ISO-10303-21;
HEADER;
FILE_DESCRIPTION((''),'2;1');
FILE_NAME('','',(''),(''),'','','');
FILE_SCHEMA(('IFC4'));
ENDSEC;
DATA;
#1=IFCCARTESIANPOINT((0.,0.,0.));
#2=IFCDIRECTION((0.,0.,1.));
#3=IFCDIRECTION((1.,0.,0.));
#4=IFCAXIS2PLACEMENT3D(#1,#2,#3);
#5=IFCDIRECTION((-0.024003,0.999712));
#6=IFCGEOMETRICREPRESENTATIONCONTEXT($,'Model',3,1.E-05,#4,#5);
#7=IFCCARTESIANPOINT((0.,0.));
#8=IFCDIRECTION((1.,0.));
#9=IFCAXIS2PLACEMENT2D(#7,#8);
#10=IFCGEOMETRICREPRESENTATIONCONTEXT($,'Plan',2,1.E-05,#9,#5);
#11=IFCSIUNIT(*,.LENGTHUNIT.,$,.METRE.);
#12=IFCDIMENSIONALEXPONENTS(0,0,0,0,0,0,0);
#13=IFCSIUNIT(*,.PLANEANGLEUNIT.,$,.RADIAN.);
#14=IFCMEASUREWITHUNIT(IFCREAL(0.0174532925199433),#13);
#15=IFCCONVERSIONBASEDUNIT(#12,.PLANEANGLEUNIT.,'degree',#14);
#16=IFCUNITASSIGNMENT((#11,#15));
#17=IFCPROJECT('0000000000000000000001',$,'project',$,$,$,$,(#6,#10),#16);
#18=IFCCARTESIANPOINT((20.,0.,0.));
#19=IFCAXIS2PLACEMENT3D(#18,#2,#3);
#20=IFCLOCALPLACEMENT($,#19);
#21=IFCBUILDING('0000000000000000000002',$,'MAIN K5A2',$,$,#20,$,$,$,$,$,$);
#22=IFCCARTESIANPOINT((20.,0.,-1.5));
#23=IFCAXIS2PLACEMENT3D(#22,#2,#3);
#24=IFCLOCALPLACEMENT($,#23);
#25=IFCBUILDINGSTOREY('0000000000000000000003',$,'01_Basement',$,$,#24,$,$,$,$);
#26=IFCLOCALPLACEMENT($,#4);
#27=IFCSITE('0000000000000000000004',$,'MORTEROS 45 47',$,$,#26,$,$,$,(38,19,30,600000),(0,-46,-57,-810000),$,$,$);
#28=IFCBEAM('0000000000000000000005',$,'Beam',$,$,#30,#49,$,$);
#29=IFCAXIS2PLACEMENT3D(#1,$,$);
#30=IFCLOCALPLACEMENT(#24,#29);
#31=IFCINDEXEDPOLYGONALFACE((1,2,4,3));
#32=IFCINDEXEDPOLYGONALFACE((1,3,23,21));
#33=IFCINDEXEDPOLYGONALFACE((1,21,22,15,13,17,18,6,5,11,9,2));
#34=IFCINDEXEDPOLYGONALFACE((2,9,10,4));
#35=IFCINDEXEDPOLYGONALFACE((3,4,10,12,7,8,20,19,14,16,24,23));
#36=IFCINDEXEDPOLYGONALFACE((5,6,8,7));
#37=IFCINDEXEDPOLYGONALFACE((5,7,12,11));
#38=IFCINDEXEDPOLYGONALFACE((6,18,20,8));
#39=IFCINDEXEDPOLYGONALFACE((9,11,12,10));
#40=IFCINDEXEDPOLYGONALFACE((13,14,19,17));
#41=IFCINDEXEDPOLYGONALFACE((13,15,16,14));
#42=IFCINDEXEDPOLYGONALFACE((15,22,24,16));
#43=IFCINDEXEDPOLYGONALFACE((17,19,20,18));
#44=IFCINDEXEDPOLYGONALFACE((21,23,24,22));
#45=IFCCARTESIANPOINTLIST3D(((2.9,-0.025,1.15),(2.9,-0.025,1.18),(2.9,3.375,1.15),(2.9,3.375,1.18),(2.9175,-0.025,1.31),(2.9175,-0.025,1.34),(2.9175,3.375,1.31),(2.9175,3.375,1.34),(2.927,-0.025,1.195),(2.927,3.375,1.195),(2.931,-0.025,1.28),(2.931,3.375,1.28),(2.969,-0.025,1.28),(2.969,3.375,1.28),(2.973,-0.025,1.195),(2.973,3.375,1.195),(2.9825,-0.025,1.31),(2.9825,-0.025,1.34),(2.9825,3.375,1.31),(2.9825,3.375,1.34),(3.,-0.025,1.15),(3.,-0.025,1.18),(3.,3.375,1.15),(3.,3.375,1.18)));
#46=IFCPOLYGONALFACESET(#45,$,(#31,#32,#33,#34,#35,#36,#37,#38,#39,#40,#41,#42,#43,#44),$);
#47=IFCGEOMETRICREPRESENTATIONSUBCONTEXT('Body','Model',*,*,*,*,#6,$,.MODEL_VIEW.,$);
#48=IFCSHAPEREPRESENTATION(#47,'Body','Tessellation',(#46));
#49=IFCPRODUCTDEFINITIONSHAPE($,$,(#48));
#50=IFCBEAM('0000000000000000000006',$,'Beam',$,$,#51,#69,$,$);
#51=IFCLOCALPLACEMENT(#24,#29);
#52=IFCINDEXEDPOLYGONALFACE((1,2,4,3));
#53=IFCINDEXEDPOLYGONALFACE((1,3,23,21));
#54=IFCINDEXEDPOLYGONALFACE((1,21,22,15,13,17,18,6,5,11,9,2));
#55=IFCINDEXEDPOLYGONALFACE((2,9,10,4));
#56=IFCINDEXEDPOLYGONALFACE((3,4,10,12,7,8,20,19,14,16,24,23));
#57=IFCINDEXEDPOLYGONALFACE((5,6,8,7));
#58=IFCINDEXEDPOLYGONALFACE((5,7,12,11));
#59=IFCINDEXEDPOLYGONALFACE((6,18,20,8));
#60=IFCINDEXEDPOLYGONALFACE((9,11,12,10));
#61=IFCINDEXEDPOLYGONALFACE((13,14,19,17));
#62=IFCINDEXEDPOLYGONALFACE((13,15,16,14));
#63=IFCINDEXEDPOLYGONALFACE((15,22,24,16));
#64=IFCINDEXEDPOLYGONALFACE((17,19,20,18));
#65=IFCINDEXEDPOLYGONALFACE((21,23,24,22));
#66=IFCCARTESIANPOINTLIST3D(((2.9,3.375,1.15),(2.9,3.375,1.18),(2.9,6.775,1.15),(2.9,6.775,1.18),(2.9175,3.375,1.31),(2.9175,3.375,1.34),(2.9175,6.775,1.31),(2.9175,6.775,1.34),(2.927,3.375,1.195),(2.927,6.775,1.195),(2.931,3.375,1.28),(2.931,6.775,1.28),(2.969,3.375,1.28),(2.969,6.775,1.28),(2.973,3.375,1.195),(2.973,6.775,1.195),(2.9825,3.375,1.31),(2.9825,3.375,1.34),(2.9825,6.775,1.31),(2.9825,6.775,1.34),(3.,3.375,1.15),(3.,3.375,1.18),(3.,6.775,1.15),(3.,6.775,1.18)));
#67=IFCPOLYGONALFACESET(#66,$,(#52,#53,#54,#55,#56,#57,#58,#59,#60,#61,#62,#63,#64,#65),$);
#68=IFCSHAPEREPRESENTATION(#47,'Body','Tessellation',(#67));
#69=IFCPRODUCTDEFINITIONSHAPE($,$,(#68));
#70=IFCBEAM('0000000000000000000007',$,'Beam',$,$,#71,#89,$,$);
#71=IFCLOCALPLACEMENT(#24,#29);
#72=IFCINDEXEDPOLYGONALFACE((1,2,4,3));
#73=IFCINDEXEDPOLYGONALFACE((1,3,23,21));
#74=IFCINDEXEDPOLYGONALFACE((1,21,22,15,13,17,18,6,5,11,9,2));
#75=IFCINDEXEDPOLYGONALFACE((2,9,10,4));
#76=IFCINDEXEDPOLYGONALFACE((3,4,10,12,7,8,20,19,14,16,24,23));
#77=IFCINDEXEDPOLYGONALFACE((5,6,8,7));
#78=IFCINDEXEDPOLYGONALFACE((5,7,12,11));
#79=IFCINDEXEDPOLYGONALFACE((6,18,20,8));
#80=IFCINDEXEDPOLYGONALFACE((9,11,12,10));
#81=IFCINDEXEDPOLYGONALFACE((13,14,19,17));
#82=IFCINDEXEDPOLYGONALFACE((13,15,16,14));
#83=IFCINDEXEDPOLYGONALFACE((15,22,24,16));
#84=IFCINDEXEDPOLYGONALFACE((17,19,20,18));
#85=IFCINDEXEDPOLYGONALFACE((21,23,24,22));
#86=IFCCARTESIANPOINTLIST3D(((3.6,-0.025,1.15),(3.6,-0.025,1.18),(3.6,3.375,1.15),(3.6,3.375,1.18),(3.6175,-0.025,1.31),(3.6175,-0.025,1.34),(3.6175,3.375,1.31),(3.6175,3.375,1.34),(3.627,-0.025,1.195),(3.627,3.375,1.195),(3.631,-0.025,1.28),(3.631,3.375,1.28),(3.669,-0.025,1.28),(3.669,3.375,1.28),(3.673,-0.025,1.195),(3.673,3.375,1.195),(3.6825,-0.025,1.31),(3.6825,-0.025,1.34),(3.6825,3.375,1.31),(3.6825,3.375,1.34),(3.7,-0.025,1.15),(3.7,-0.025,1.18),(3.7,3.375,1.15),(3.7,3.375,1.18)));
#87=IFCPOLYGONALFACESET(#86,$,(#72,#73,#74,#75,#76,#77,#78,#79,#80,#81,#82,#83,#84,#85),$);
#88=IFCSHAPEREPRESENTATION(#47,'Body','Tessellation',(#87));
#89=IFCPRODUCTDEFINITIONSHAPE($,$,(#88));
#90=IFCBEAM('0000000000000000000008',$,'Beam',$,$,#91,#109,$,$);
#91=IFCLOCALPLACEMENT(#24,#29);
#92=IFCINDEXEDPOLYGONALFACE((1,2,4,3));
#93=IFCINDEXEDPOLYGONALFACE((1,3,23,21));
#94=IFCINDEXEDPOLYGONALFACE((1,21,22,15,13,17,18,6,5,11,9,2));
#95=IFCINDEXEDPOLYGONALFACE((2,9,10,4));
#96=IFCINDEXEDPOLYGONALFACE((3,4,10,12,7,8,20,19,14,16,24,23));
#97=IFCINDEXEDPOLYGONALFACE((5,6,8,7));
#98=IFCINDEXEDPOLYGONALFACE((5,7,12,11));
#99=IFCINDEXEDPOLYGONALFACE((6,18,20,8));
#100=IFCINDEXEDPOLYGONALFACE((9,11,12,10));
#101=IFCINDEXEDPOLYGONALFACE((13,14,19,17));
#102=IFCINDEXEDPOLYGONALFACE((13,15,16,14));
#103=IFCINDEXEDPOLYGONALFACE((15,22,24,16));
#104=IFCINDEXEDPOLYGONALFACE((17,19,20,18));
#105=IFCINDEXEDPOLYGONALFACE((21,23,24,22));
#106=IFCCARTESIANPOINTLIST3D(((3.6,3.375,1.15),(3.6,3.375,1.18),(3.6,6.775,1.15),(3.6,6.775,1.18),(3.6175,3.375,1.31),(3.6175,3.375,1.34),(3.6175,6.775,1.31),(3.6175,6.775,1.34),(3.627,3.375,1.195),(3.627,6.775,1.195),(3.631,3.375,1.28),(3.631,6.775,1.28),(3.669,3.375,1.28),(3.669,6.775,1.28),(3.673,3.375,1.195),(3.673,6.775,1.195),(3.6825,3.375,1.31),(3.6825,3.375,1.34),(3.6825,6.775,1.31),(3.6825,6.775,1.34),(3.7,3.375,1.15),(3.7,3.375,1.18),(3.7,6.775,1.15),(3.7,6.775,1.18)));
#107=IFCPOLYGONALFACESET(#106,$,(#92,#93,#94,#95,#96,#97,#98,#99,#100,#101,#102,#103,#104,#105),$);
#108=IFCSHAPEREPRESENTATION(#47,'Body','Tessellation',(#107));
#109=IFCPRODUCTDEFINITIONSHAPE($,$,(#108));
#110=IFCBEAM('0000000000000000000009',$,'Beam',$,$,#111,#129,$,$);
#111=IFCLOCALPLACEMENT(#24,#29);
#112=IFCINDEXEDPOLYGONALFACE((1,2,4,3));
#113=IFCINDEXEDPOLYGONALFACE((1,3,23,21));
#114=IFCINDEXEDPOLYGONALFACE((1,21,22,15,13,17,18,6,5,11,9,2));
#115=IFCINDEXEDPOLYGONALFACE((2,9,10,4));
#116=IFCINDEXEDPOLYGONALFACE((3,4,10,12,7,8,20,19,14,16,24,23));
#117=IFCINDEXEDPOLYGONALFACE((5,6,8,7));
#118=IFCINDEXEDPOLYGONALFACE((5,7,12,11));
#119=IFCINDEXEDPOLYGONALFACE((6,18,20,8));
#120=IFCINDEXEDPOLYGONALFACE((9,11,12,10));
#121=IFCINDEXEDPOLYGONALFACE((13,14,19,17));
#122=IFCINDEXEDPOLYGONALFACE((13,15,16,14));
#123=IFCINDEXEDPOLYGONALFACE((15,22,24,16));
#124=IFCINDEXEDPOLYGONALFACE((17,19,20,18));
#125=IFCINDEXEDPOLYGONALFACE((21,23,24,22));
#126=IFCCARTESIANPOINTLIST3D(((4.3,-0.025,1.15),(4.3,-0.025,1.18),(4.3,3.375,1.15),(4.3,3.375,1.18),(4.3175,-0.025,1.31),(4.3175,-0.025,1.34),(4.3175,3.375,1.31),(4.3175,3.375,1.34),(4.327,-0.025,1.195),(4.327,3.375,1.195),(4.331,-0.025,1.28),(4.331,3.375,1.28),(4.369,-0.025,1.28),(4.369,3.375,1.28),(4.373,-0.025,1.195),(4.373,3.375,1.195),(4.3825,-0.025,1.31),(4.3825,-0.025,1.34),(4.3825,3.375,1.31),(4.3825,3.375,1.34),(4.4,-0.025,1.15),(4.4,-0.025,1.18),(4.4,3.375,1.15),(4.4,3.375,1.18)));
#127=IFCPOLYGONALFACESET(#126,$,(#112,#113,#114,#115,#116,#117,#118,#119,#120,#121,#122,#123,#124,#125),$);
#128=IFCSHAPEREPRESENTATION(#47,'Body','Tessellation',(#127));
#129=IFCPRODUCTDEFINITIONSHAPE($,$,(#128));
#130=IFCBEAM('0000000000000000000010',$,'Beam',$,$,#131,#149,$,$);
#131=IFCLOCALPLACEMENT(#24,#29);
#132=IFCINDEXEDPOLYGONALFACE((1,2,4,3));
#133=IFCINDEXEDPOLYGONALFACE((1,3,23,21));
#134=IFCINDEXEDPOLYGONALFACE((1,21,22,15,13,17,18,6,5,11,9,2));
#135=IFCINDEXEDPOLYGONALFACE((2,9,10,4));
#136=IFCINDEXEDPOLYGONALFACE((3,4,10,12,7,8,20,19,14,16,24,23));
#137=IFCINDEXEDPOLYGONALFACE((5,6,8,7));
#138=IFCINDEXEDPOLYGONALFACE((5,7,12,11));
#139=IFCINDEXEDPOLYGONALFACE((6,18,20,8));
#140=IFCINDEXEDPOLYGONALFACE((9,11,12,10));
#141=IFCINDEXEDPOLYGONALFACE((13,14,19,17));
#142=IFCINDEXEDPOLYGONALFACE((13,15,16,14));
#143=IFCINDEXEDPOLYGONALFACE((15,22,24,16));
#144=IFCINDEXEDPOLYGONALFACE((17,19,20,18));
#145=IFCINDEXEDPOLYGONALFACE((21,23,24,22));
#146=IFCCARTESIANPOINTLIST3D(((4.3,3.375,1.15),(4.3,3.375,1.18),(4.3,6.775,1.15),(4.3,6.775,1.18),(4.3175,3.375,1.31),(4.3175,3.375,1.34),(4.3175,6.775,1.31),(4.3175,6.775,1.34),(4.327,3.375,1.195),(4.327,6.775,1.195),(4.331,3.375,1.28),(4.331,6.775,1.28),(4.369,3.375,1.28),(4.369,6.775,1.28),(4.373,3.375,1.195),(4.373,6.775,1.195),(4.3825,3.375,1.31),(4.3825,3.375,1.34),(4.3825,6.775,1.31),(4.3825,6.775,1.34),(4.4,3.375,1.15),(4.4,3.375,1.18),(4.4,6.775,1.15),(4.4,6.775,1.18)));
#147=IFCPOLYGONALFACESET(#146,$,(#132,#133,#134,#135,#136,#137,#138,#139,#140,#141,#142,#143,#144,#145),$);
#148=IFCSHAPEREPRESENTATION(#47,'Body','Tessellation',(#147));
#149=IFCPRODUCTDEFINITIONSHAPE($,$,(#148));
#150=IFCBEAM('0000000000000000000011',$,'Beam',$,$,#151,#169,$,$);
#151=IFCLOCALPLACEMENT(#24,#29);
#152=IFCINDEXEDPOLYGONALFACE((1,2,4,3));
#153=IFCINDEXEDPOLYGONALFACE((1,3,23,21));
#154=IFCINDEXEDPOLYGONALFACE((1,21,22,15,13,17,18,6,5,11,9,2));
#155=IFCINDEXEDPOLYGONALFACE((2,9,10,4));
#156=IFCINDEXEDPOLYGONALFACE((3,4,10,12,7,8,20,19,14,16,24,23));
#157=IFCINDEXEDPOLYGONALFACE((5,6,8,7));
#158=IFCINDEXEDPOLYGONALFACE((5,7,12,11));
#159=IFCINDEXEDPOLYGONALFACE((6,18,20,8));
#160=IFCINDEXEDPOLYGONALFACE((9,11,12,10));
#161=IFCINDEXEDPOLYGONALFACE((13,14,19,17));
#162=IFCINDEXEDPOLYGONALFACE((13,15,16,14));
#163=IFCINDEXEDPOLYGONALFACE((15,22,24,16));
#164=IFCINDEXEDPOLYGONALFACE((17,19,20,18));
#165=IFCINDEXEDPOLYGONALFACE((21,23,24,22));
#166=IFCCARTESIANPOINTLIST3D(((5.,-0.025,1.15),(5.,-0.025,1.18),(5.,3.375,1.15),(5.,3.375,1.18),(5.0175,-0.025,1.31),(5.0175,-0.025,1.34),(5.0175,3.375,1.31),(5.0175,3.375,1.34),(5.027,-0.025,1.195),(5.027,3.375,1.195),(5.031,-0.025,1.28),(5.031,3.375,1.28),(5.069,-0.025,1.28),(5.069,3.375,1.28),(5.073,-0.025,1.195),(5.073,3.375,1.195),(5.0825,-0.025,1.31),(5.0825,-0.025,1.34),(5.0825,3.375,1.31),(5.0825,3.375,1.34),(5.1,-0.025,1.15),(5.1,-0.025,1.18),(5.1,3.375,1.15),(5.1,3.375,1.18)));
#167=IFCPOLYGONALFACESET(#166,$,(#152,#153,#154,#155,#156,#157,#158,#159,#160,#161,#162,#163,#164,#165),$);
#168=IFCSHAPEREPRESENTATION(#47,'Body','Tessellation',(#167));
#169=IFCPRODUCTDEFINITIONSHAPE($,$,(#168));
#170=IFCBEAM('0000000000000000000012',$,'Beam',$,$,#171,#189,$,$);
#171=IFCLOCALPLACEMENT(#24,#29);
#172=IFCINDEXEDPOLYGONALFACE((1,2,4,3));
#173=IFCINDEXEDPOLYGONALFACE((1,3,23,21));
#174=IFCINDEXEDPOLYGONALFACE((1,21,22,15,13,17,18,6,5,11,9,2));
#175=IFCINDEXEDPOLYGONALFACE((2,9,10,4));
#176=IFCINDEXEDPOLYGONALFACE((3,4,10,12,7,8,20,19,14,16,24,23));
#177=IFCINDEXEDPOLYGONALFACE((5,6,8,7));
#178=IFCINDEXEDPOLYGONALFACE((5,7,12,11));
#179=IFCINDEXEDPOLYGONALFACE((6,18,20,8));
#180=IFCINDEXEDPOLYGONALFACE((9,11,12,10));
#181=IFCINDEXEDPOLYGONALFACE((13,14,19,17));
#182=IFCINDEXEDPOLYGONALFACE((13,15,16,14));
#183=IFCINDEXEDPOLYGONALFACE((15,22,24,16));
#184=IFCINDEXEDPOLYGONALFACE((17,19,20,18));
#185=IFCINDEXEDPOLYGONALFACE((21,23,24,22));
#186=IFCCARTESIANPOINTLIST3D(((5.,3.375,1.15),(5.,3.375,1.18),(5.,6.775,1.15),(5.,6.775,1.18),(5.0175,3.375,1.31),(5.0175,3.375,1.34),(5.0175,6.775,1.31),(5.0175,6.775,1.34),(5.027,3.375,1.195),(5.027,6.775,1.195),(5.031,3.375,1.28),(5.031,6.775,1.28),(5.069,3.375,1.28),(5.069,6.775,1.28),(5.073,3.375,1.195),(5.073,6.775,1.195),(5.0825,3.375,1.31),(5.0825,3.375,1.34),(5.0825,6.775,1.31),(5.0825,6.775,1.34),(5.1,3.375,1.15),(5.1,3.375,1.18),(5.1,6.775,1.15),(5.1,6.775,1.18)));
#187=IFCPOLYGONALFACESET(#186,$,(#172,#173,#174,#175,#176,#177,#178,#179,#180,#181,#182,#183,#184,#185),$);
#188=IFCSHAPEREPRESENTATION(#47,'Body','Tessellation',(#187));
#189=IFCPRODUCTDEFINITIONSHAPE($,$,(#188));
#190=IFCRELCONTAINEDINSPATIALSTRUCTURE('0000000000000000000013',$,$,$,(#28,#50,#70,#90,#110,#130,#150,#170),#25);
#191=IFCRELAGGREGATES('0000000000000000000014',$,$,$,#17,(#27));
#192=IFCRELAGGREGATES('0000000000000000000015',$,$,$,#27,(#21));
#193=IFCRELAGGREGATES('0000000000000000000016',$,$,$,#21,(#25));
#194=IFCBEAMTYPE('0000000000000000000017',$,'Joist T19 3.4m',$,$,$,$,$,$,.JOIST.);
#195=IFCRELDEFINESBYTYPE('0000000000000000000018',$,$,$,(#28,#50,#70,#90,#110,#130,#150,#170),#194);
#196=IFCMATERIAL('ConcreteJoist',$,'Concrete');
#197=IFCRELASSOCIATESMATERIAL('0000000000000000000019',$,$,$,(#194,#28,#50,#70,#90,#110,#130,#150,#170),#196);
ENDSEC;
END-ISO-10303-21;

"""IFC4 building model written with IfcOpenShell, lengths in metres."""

from ifc_helpers import new_model, entity, si_unit, converted_unit, direction, frame, origin_with_axes, origin_2d_with_axis, place, context, subcontext, project, spatial, indexed_curve, outline, extrude, material, material_profile, profile_set, profile_usage, type_object, element, save


model = new_model("IFC4")

# Units and contexts
model_context = context("Model", 3, precision=1e-05, world=origin_with_axes(), true_north=direction((-0.024003, 0.999712)))
plan_context = context("Plan", 2, precision=1e-05, world=origin_2d_with_axis(), true_north=direction((-0.024003, 0.999712)))
body_context = subcontext(model_context, "Body", "Model", "MODEL_VIEW")
ifc_project = project(units=[si_unit("LENGTHUNIT", "METRE"), converted_unit("PLANEANGLEUNIT", "degree", entity("IfcReal", 0.0174532925199433), si_unit("PLANEANGLEUNIT", "RADIAN"), dimensions=[0, 0, 0, 0, 0, 0, 0])], contexts=[model_context, plan_context])

# Site, building, storey
site_placement = place(None, origin_with_axes())
site = spatial("IfcSite", under=ifc_project, at=site_placement, Name="MORTEROS 45 47", RefLatitude=(38, 19, 30, 600000), RefLongitude=(0, -46, -57, -810000))
building_placement = place(None, frame((20.0, 0.0, 0.0), z_axis=(0.0, 0.0, 1.0), x_axis=(1.0, 0.0, 0.0)))
building = spatial("IfcBuilding", under=site, at=building_placement, Name="MAIN K5A2")
storey_placement = place(None, frame((20.0, 0.0, -1.5), z_axis=(0.0, 0.0, 1.0), x_axis=(1.0, 0.0, 0.0)))
storey = spatial("IfcBuildingStorey", under=building, at=storey_placement, Name="01_Basement")

# Beams
ifc_material = material(Name="ConcreteJoist", Category="Concrete")
ifc_material_profile = material_profile(ifc_material, outline(indexed_curve([(0.019, 0.13), (0.023, 0.045), (0.05, 0.03), (0.05, 0.0), (-0.05, 0.0), (-0.05, 0.03), (-0.023, 0.045), (-0.019, 0.13), (-0.0325, 0.16), (-0.0325, 0.19), (0.0325, 0.19), (0.0325, 0.16), (0.019, 0.13)])))
ifc_profile_set = profile_set([ifc_material_profile], Name="JoistMaterialProfileSet")
beam_type = type_object("IfcBeamType", Name="Joist T19 3.4m", PredefinedType="JOIST", material=ifc_profile_set)
ifc_profile_usage_1 = profile_usage(ifc_profile_set, cardinal=5)
beam_1_placement = place(None, frame((22.95, -0.025, -0.35), z_axis=(0.0, 1.0, 0.0), x_axis=(-1.0, 0.0, 0.0)))
element("IfcBeam", 1, at=beam_1_placement, inside=storey, type_object=beam_type, material=ifc_profile_usage_1, Name="Beam", context=body_context, shape_type="SweptSolid", body=[
    extrude(outline(indexed_curve([(0.019, 0.13), (0.023, 0.045), (0.05, 0.03), (0.05, 0.0), (-0.05, 0.0), (-0.05, 0.03), (-0.023, 0.045), (-0.019, 0.13), (-0.0325, 0.16), (-0.0325, 0.19), (0.0325, 0.19), (0.0325, 0.16), (0.019, 0.13)])), origin_with_axes(), (0.0, 0.0, 1.0), 3.4),
])
ifc_profile_usage_2 = profile_usage(ifc_profile_set, cardinal=5)
beam_2_placement = place(None, frame((22.95, 3.375, -0.35), z_axis=(0.0, 1.0, 0.0), x_axis=(-1.0, 0.0, 0.0)))
element("IfcBeam", 2, at=beam_2_placement, inside=storey, type_object=beam_type, material=ifc_profile_usage_2, Name="Beam", context=body_context, shape_type="SweptSolid", body=[
    extrude(outline(indexed_curve([(0.019, 0.13), (0.023, 0.045), (0.05, 0.03), (0.05, 0.0), (-0.05, 0.0), (-0.05, 0.03), (-0.023, 0.045), (-0.019, 0.13), (-0.0325, 0.16), (-0.0325, 0.19), (0.0325, 0.19), (0.0325, 0.16), (0.019, 0.13)])), origin_with_axes(), (0.0, 0.0, 1.0), 3.4),
])
ifc_profile_usage_3 = profile_usage(ifc_profile_set, cardinal=5)
beam_3_placement = place(None, frame((23.65, -0.025, -0.35), z_axis=(0.0, 1.0, 0.0), x_axis=(-1.0, 0.0, 0.0)))
element("IfcBeam", 3, at=beam_3_placement, inside=storey, type_object=beam_type, material=ifc_profile_usage_3, Name="Beam", context=body_context, shape_type="SweptSolid", body=[
    extrude(outline(indexed_curve([(0.019, 0.13), (0.023, 0.045), (0.05, 0.03), (0.05, 0.0), (-0.05, 0.0), (-0.05, 0.03), (-0.023, 0.045), (-0.019, 0.13), (-0.0325, 0.16), (-0.0325, 0.19), (0.0325, 0.19), (0.0325, 0.16), (0.019, 0.13)])), origin_with_axes(), (0.0, 0.0, 1.0), 3.4),
])
ifc_profile_usage_4 = profile_usage(ifc_profile_set, cardinal=5)
beam_4_placement = place(None, frame((23.65, 3.375, -0.35), z_axis=(0.0, 1.0, 0.0), x_axis=(-1.0, 0.0, 0.0)))
element("IfcBeam", 4, at=beam_4_placement, inside=storey, type_object=beam_type, material=ifc_profile_usage_4, Name="Beam", context=body_context, shape_type="SweptSolid", body=[
    extrude(outline(indexed_curve([(0.019, 0.13), (0.023, 0.045), (0.05, 0.03), (0.05, 0.0), (-0.05, 0.0), (-0.05, 0.03), (-0.023, 0.045), (-0.019, 0.13), (-0.0325, 0.16), (-0.0325, 0.19), (0.0325, 0.19), (0.0325, 0.16), (0.019, 0.13)])), origin_with_axes(), (0.0, 0.0, 1.0), 3.4),
])
ifc_profile_usage_5 = profile_usage(ifc_profile_set, cardinal=5)
beam_5_placement = place(None, frame((24.35, -0.025, -0.35), z_axis=(0.0, 1.0, 0.0), x_axis=(-1.0, 0.0, 0.0)))
element("IfcBeam", 5, at=beam_5_placement, inside=storey, type_object=beam_type, material=ifc_profile_usage_5, Name="Beam", context=body_context, shape_type="SweptSolid", body=[
    extrude(outline(indexed_curve([(0.019, 0.13), (0.023, 0.045), (0.05, 0.03), (0.05, 0.0), (-0.05, 0.0), (-0.05, 0.03), (-0.023, 0.045), (-0.019, 0.13), (-0.0325, 0.16), (-0.0325, 0.19), (0.0325, 0.19), (0.0325, 0.16), (0.019, 0.13)])), origin_with_axes(), (0.0, 0.0, 1.0), 3.4),
])
ifc_profile_usage_6 = profile_usage(ifc_profile_set, cardinal=5)
beam_6_placement = place(None, frame((24.35, 3.375, -0.35), z_axis=(0.0, 1.0, 0.0), x_axis=(-1.0, 0.0, 0.0)))
element("IfcBeam", 6, at=beam_6_placement, inside=storey, type_object=beam_type, material=ifc_profile_usage_6, Name="Beam", context=body_context, shape_type="SweptSolid", body=[
    extrude(outline(indexed_curve([(0.019, 0.13), (0.023, 0.045), (0.05, 0.03), (0.05, 0.0), (-0.05, 0.0), (-0.05, 0.03), (-0.023, 0.045), (-0.019, 0.13), (-0.0325, 0.16), (-0.0325, 0.19), (0.0325, 0.19), (0.0325, 0.16), (0.019, 0.13)])), origin_with_axes(), (0.0, 0.0, 1.0), 3.4),
])
ifc_profile_usage_7 = profile_usage(ifc_profile_set, cardinal=5)
beam_7_placement = place(None, frame((25.05, -0.025, -0.35), z_axis=(0.0, 1.0, 0.0), x_axis=(-1.0, 0.0, 0.0)))
element("IfcBeam", 7, at=beam_7_placement, inside=storey, type_object=beam_type, material=ifc_profile_usage_7, Name="Beam", context=body_context, shape_type="SweptSolid", body=[
    extrude(outline(indexed_curve([(0.019, 0.13), (0.023, 0.045), (0.05, 0.03), (0.05, 0.0), (-0.05, 0.0), (-0.05, 0.03), (-0.023, 0.045), (-0.019, 0.13), (-0.0325, 0.16), (-0.0325, 0.19), (0.0325, 0.19), (0.0325, 0.16), (0.019, 0.13)])), origin_with_axes(), (0.0, 0.0, 1.0), 3.4),
])
ifc_profile_usage_8 = profile_usage(ifc_profile_set, cardinal=5)
beam_8_placement = place(None, frame((25.05, 3.375, -0.35), z_axis=(0.0, 1.0, 0.0), x_axis=(-1.0, 0.0, 0.0)))
element("IfcBeam", 8, at=beam_8_placement, inside=storey, type_object=beam_type, material=ifc_profile_usage_8, Name="Beam", context=body_context, shape_type="SweptSolid", body=[
    extrude(outline(indexed_curve([(0.019, 0.13), (0.023, 0.045), (0.05, 0.03), (0.05, 0.0), (-0.05, 0.0), (-0.05, 0.03), (-0.023, 0.045), (-0.019, 0.13), (-0.0325, 0.16), (-0.0325, 0.19), (0.0325, 0.19), (0.0325, 0.16), (0.019, 0.13)])), origin_with_axes(), (0.0, 0.0, 1.0), 3.4),
])

save(model, "model.ifc")
